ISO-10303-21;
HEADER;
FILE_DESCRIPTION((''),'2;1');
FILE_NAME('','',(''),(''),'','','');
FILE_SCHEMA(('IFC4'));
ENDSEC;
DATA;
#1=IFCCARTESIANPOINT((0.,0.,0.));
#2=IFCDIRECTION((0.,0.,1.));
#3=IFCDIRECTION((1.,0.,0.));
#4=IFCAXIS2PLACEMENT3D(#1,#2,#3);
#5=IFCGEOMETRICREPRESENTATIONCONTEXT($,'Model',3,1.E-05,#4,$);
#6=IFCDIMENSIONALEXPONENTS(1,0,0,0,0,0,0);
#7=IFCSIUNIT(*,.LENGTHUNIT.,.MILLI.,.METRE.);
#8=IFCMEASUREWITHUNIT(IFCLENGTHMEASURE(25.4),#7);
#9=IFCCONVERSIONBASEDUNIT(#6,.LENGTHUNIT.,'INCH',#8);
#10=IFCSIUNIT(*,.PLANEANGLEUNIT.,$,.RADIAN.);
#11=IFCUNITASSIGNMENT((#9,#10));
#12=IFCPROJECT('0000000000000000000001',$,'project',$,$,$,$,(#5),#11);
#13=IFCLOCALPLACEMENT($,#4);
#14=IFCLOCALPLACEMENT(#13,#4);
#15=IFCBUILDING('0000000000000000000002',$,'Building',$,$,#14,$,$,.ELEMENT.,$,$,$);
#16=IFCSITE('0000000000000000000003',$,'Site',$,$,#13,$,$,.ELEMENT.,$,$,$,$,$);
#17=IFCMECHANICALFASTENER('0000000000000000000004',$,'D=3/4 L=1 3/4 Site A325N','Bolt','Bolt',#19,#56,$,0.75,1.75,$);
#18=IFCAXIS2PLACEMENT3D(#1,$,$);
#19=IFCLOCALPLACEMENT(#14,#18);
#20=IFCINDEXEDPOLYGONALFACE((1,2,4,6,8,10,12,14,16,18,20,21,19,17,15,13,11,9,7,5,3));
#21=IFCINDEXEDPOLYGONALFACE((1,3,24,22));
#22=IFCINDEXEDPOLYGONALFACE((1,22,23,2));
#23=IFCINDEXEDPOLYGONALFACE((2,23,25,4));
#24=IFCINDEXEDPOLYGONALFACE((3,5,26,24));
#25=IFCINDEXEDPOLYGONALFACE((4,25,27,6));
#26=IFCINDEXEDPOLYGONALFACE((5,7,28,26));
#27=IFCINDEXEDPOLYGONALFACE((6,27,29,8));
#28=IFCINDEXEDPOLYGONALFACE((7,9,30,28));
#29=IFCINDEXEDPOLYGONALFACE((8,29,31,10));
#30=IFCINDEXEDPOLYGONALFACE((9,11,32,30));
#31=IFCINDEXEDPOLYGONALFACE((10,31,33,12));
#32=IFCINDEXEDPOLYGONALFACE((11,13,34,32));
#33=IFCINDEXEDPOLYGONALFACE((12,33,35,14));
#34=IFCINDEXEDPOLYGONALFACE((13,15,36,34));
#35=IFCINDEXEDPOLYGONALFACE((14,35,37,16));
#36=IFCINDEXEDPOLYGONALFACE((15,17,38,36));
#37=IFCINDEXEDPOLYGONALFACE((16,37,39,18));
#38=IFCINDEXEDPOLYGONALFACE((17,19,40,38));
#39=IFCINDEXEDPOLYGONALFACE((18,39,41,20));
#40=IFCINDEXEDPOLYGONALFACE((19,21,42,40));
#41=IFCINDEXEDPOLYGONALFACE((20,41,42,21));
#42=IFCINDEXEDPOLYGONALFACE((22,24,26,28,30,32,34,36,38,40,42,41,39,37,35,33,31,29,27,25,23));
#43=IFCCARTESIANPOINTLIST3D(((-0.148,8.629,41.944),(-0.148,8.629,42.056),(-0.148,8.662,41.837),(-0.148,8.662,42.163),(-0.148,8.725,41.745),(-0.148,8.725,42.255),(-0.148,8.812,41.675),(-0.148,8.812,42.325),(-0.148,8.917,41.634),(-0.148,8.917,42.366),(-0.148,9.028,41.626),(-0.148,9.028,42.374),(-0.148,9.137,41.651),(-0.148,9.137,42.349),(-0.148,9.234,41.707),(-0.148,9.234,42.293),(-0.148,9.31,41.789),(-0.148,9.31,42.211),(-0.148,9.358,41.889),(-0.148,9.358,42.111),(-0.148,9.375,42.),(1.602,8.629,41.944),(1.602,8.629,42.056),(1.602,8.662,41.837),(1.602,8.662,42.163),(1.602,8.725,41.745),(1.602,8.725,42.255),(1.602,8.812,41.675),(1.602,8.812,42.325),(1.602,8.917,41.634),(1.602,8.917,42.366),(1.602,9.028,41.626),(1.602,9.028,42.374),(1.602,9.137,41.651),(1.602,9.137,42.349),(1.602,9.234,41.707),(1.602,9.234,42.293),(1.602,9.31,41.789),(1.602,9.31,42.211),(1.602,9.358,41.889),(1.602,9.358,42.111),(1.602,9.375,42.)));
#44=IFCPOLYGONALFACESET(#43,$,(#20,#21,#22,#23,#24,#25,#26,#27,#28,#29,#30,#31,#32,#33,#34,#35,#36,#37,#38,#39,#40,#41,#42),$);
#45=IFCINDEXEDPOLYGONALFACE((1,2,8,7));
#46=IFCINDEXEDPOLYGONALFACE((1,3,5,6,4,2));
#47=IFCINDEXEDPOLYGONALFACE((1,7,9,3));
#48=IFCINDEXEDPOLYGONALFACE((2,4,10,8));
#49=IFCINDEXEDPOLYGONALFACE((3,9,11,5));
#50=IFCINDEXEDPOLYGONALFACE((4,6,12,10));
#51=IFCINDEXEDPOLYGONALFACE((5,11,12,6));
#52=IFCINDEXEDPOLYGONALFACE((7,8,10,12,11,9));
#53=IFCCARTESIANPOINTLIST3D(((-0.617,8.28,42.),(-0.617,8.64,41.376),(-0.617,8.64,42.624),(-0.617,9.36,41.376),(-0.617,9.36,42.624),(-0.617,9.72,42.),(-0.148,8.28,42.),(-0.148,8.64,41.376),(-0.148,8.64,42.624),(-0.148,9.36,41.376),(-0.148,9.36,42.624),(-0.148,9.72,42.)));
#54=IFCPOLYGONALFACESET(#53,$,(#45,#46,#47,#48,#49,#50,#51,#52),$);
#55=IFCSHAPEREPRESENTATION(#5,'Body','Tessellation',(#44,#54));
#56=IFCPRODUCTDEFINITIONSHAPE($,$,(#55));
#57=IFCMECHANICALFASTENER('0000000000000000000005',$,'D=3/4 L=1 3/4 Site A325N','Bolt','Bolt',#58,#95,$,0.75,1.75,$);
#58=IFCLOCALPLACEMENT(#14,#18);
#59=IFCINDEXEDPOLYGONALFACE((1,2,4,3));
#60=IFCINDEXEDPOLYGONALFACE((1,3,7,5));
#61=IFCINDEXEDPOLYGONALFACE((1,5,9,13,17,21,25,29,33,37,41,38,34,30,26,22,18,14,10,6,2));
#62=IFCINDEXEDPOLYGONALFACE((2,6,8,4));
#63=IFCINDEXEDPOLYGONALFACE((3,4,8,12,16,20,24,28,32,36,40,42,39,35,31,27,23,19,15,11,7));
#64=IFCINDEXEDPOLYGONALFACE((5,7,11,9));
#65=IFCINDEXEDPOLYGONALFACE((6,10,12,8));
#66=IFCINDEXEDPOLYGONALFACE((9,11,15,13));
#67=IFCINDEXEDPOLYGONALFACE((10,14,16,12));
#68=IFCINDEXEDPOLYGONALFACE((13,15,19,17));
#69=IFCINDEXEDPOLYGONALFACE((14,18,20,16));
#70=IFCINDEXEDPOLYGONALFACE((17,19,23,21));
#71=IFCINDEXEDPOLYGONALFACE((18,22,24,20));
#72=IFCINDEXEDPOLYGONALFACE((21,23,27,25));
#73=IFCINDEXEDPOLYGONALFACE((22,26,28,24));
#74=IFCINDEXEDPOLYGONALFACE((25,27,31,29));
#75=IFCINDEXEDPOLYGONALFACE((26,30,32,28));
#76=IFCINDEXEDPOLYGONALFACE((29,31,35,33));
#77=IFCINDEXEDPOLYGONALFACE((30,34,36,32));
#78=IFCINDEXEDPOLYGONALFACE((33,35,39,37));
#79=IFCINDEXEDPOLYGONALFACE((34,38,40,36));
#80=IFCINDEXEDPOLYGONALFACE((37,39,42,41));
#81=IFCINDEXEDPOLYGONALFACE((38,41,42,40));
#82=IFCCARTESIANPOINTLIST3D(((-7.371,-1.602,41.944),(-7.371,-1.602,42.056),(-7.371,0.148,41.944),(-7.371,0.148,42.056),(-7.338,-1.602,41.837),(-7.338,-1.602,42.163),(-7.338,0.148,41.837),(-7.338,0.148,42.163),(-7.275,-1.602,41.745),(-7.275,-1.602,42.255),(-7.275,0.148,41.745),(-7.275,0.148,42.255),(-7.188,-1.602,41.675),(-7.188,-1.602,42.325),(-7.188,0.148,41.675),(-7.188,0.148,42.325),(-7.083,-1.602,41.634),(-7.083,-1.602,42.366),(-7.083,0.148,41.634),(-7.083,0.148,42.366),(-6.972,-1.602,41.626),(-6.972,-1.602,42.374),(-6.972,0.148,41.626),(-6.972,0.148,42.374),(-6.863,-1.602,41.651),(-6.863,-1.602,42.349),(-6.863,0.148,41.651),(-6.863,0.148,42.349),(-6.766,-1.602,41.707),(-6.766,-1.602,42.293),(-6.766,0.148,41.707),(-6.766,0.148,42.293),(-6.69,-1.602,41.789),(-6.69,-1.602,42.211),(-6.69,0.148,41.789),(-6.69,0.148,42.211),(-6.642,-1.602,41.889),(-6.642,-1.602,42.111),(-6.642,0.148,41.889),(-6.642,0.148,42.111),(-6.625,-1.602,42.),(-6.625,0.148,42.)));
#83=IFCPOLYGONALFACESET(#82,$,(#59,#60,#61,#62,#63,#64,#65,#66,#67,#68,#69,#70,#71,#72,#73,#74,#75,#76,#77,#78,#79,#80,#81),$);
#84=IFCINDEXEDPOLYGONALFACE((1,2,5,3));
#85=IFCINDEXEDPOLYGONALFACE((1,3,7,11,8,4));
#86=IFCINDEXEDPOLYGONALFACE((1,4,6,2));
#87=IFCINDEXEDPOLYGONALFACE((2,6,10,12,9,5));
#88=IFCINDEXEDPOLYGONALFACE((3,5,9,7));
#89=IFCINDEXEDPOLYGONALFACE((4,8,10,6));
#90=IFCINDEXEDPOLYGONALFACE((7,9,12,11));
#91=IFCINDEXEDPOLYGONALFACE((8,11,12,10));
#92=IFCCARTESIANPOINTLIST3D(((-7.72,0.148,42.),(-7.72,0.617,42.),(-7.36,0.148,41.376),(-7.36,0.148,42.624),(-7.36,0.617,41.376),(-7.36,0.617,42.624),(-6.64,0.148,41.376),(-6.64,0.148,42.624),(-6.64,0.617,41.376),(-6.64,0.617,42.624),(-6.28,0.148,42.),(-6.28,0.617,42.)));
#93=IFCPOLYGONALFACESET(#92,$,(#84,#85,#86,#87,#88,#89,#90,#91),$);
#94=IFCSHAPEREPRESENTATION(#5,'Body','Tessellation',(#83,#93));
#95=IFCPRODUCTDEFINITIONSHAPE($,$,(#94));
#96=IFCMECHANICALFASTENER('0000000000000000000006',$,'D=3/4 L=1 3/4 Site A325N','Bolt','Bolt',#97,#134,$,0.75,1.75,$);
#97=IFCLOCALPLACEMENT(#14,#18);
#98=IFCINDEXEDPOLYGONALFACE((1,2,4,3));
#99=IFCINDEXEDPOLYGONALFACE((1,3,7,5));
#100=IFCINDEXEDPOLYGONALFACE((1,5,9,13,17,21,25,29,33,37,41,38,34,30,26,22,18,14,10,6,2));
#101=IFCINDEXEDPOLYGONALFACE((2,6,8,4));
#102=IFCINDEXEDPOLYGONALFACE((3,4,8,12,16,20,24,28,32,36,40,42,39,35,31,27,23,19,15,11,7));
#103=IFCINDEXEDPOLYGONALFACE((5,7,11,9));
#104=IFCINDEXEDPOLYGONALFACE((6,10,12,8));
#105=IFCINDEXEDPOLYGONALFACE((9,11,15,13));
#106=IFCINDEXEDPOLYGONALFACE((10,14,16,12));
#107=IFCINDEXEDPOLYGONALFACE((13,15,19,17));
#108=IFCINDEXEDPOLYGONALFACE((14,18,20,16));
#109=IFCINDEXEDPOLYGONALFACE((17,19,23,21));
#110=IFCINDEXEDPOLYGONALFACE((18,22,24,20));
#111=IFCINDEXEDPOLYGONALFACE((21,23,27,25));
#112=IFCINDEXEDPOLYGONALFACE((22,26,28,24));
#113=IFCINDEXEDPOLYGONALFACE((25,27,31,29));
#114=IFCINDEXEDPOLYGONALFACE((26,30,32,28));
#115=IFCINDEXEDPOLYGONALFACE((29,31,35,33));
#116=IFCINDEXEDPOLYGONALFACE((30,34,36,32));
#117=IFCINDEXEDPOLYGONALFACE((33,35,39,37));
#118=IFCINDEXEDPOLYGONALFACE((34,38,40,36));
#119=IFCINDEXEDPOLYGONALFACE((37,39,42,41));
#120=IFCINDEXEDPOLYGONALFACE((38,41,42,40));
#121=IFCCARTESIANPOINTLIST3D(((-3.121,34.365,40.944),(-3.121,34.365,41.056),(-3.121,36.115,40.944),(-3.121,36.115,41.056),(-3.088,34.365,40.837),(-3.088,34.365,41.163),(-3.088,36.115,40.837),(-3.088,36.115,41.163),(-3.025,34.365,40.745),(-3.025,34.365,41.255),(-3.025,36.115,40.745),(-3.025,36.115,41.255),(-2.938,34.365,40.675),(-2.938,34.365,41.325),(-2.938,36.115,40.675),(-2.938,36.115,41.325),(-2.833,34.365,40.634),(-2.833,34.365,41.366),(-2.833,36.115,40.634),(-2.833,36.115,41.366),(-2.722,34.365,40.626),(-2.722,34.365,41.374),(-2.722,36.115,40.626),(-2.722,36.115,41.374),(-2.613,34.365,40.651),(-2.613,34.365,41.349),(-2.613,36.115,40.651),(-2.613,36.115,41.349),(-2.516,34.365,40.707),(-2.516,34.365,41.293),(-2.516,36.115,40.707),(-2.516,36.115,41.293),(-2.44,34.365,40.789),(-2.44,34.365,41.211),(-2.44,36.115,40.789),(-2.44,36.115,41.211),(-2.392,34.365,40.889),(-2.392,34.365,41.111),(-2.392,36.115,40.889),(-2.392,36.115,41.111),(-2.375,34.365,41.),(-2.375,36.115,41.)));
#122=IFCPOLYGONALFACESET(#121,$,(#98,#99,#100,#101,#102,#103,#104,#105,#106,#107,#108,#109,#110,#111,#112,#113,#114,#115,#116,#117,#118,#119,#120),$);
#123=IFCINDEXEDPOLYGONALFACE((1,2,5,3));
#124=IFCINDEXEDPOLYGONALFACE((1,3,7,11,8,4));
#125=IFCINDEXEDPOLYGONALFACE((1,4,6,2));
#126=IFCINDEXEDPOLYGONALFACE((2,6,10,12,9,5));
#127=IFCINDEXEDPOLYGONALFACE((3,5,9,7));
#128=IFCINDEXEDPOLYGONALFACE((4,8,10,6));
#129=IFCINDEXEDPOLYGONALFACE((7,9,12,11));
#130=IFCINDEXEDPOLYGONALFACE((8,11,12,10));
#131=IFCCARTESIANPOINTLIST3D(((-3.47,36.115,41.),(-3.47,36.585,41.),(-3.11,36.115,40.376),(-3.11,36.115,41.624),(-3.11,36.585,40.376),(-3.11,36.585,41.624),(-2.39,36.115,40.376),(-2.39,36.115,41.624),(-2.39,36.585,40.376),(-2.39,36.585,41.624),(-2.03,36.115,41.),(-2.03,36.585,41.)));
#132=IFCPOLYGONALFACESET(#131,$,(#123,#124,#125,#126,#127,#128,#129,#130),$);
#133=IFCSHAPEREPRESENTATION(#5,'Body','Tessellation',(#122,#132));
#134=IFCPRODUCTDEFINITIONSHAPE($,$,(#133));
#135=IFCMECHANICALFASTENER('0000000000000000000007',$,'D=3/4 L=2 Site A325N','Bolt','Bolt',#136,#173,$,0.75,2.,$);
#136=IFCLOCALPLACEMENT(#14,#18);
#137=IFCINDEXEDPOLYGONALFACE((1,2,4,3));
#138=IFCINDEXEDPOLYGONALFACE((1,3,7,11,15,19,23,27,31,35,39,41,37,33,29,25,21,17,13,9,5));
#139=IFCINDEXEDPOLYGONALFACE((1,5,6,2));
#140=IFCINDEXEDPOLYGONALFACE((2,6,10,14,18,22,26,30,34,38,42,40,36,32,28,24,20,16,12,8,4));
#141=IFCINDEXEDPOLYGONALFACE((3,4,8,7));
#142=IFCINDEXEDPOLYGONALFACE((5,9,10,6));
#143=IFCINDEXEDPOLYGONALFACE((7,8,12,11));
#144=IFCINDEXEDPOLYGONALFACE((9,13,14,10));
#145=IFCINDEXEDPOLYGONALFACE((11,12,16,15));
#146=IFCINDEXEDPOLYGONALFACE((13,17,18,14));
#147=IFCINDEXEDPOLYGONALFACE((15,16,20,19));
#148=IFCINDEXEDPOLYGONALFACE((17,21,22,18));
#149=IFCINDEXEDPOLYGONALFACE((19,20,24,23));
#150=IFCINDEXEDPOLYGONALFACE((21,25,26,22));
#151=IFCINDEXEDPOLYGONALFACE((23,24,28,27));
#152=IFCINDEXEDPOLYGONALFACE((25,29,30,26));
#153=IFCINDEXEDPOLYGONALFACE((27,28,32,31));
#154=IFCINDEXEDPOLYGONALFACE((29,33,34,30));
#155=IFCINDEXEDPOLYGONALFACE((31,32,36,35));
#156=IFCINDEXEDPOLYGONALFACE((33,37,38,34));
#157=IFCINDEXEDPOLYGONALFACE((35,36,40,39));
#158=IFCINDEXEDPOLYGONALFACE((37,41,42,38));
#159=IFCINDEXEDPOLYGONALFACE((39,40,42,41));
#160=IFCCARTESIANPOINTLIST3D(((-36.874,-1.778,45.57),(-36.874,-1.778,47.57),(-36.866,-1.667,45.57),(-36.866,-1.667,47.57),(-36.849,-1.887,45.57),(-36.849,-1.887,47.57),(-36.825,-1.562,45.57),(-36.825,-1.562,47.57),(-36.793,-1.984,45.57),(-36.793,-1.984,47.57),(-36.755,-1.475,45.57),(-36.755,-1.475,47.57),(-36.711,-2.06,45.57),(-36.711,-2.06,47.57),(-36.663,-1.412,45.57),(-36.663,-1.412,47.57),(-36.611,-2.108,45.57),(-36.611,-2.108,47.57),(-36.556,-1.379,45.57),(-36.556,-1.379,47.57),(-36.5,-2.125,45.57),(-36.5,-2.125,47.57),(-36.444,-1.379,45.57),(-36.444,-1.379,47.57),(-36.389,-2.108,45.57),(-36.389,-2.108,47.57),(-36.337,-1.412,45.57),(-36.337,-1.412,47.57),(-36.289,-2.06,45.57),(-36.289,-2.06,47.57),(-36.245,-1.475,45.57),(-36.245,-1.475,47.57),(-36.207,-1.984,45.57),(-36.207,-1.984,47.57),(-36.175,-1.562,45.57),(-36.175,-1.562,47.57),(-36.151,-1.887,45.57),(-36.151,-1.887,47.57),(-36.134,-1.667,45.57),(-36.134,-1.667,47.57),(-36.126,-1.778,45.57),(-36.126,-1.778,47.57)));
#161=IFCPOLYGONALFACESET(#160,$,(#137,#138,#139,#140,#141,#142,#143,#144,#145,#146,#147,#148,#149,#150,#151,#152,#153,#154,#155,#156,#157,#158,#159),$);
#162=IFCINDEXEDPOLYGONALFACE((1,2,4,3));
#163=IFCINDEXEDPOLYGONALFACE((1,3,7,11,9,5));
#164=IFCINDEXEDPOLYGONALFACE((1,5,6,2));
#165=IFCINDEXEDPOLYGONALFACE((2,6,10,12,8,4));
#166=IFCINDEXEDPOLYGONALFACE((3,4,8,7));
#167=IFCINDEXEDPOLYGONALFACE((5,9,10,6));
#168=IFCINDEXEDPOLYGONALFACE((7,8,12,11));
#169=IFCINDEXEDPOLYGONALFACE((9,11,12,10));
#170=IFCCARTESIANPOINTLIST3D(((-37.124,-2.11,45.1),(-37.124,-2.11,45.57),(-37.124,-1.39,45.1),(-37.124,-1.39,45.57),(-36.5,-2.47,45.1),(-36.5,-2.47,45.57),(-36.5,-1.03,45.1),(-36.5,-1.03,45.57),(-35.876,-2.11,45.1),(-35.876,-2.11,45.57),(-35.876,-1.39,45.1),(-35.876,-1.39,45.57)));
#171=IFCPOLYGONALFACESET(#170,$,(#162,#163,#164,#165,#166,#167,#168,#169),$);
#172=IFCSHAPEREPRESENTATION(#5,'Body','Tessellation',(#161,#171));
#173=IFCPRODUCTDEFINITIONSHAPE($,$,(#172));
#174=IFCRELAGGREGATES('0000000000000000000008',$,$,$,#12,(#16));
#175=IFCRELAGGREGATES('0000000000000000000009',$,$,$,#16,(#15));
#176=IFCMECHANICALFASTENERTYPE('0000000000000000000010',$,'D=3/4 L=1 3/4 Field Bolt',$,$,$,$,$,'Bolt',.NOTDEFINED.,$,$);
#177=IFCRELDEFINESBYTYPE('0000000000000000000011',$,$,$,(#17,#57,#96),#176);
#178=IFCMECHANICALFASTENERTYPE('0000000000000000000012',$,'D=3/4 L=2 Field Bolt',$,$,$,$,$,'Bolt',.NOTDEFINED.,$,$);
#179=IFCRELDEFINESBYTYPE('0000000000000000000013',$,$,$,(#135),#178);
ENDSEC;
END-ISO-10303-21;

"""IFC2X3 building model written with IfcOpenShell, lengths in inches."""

from ifc_helpers import new_model, entity, si_unit, converted_unit, frame, origin_with_axes, origin_2d_with_axis, place, context, project, spatial, polyline, circle, outline, extrude, source, transform, mapped, type_object, type_shapes, element, save


model = new_model("IFC2X3")

# Units and contexts
model_context = context("Model", 3, precision=1e-05, world=origin_with_axes())
ifc_project = project(units=[converted_unit("LENGTHUNIT", "INCH", entity("IfcLengthMeasure", 25.4), si_unit("LENGTHUNIT", "METRE", prefix="MILLI"), dimensions=[1, 0, 0, 0, 0, 0, 0]), si_unit("PLANEANGLEUNIT", "RADIAN")], contexts=[model_context])

# Site, building
site_placement = place(None, origin_with_axes())
site = spatial("IfcSite", under=ifc_project, at=site_placement, Name="Site", CompositionType="ELEMENT")
building_placement = place(site_placement, origin_with_axes())
building = spatial("IfcBuilding", under=site, at=building_placement, Name="Building", CompositionType="ELEMENT")

# Shared definitions
assembly_1_placement = place(building_placement, frame((0.0, 0.0, 46.0), z_axis=(0.0, 0.0, 1.0), x_axis=(0.0, 1.0, 0.0)))

# Shared definitions
assembly_2_placement = place(building_placement, frame((0.0, 0.0, 46.0), z_axis=(0.0, 0.0, 1.0), x_axis=(-1.0, 0.0, 0.0)))

# Shared definitions
assembly_3_placement = place(building_placement, frame((0.0, 36.0, 44.0), z_axis=(0.0, 0.0, 1.0), x_axis=(-1.0, 0.0, 0.0)))

# Mechanical fasteners
mechanical_fastener_type_1 = type_object("IfcMechanicalFastenerType", Name="D=3/4 L=1 3/4 Field Bolt", ElementType="Bolt")
shared_shape_1 = source(origin_with_axes(), model_context, "Body", "SweptSolid", [
    extrude(circle(Radius=0.375, at=origin_2d_with_axis()), frame((0.0, 0.0, 0.0), z_axis=(1.0, 0.0, 0.0), x_axis=(0.0, 1.0, 0.0)), (0.0, 0.0, 1.0), 1.75),
    extrude(outline(polyline([(-0.72, 0.0), (-0.36, 0.624), (0.36, 0.624), (0.72, 0.0), (0.36, -0.624), (-0.36, -0.624), (-0.72, 0.0)])), frame((0.0, 0.0, 0.0), z_axis=(1.0, 0.0, 0.0), x_axis=(0.0, 1.0, 0.0)), (0.0, 0.0, -1.0), 0.47),
])
type_shapes(mechanical_fastener_type_1, [shared_shape_1])
placement_1 = place(assembly_1_placement, frame((9.0, 0.148, -4.0), z_axis=(0.0, 0.0, 1.0), x_axis=(0.0, -1.0, 0.0)))
mechanical_fastener_1_placement = place(placement_1, origin_with_axes())
element("IfcMechanicalFastener", 1, at=mechanical_fastener_1_placement, type_object=mechanical_fastener_type_1, Name="D=3/4 L=1 3/4 Site A325N", Description="Bolt", ObjectType="Bolt", NominalDiameter=0.75, NominalLength=1.75, context=model_context, shape_type="MappedRepresentation", body=[
    mapped(shared_shape_1, transform((0.0, 0.0, 0.0), scale=1.0)),
])
placement_2 = place(assembly_2_placement, frame((7.0, -0.148, -4.0), z_axis=(0.0, 0.0, 1.0), x_axis=(0.0, 1.0, 0.0)))
mechanical_fastener_2_placement = place(placement_2, origin_with_axes())
element("IfcMechanicalFastener", 2, at=mechanical_fastener_2_placement, type_object=mechanical_fastener_type_1, Name="D=3/4 L=1 3/4 Site A325N", Description="Bolt", ObjectType="Bolt", NominalDiameter=0.75, NominalLength=1.75, context=model_context, shape_type="MappedRepresentation", body=[
    mapped(shared_shape_1, transform((0.0, 0.0, 0.0), scale=1.0)),
])
placement_3 = place(assembly_3_placement, frame((2.75, -0.115, -9.0), z_axis=(0.0, 0.0, 1.0), x_axis=(0.0, 1.0, 0.0)))
mechanical_fastener_3_placement = place(placement_3, frame((0.0, 0.0, 6.0), z_axis=(0.0, 0.0, 1.0), x_axis=(1.0, 0.0, 0.0)))
element("IfcMechanicalFastener", 3, at=mechanical_fastener_3_placement, type_object=mechanical_fastener_type_1, Name="D=3/4 L=1 3/4 Site A325N", Description="Bolt", ObjectType="Bolt", NominalDiameter=0.75, NominalLength=1.75, context=model_context, shape_type="MappedRepresentation", body=[
    mapped(shared_shape_1, transform((0.0, 0.0, 0.0), scale=1.0)),
])
mechanical_fastener_type_2 = type_object("IfcMechanicalFastenerType", Name="D=3/4 L=2 Field Bolt", ElementType="Bolt")
shared_shape_2 = source(origin_with_axes(), model_context, "Body", "SweptSolid", [
    extrude(circle(Radius=0.375, at=origin_2d_with_axis()), frame((0.0, 0.0, 0.0), z_axis=(1.0, 0.0, 0.0), x_axis=(0.0, 1.0, 0.0)), (0.0, 0.0, 1.0), 2.0),
    extrude(outline(polyline([(-0.72, 0.0), (-0.36, 0.624), (0.36, 0.624), (0.72, 0.0), (0.36, -0.624), (-0.36, -0.624), (-0.72, 0.0)])), frame((0.0, 0.0, 0.0), z_axis=(1.0, 0.0, 0.0), x_axis=(0.0, 1.0, 0.0)), (0.0, 0.0, -1.0), 0.47),
])
type_shapes(mechanical_fastener_type_2, [shared_shape_2])
placement_4 = place(building_placement, frame((-33.0, 0.0, 46.0), z_axis=(-1.0, 0.0, 0.0), x_axis=(0.0, 0.0, 1.0)))
placement_5 = place(placement_4, frame((-0.43, 1.75, 3.5), z_axis=(0.0, 0.0, -1.0), x_axis=(1.0, 0.0, 0.0)))
for number, where, z_axis, x_axis, name in (
    (4, (0.0, 3.5, 0.0), (0.0, 0.0, 1.0), (1.0, 0.0, 0.0), "D=3/4 L=2 Site A325N"),
):
    element("IfcMechanicalFastener", number, at=place(placement_5, frame(where, z_axis=z_axis, x_axis=x_axis)), type_object=mechanical_fastener_type_2, Name=name, Description="Bolt", ObjectType="Bolt", NominalDiameter=0.75, NominalLength=2.0, context=model_context, shape_type="MappedRepresentation", body=[
        mapped(shared_shape_2, transform((0.0, 0.0, 0.0), scale=1.0)),
    ])

save(model, "model.ifc")
